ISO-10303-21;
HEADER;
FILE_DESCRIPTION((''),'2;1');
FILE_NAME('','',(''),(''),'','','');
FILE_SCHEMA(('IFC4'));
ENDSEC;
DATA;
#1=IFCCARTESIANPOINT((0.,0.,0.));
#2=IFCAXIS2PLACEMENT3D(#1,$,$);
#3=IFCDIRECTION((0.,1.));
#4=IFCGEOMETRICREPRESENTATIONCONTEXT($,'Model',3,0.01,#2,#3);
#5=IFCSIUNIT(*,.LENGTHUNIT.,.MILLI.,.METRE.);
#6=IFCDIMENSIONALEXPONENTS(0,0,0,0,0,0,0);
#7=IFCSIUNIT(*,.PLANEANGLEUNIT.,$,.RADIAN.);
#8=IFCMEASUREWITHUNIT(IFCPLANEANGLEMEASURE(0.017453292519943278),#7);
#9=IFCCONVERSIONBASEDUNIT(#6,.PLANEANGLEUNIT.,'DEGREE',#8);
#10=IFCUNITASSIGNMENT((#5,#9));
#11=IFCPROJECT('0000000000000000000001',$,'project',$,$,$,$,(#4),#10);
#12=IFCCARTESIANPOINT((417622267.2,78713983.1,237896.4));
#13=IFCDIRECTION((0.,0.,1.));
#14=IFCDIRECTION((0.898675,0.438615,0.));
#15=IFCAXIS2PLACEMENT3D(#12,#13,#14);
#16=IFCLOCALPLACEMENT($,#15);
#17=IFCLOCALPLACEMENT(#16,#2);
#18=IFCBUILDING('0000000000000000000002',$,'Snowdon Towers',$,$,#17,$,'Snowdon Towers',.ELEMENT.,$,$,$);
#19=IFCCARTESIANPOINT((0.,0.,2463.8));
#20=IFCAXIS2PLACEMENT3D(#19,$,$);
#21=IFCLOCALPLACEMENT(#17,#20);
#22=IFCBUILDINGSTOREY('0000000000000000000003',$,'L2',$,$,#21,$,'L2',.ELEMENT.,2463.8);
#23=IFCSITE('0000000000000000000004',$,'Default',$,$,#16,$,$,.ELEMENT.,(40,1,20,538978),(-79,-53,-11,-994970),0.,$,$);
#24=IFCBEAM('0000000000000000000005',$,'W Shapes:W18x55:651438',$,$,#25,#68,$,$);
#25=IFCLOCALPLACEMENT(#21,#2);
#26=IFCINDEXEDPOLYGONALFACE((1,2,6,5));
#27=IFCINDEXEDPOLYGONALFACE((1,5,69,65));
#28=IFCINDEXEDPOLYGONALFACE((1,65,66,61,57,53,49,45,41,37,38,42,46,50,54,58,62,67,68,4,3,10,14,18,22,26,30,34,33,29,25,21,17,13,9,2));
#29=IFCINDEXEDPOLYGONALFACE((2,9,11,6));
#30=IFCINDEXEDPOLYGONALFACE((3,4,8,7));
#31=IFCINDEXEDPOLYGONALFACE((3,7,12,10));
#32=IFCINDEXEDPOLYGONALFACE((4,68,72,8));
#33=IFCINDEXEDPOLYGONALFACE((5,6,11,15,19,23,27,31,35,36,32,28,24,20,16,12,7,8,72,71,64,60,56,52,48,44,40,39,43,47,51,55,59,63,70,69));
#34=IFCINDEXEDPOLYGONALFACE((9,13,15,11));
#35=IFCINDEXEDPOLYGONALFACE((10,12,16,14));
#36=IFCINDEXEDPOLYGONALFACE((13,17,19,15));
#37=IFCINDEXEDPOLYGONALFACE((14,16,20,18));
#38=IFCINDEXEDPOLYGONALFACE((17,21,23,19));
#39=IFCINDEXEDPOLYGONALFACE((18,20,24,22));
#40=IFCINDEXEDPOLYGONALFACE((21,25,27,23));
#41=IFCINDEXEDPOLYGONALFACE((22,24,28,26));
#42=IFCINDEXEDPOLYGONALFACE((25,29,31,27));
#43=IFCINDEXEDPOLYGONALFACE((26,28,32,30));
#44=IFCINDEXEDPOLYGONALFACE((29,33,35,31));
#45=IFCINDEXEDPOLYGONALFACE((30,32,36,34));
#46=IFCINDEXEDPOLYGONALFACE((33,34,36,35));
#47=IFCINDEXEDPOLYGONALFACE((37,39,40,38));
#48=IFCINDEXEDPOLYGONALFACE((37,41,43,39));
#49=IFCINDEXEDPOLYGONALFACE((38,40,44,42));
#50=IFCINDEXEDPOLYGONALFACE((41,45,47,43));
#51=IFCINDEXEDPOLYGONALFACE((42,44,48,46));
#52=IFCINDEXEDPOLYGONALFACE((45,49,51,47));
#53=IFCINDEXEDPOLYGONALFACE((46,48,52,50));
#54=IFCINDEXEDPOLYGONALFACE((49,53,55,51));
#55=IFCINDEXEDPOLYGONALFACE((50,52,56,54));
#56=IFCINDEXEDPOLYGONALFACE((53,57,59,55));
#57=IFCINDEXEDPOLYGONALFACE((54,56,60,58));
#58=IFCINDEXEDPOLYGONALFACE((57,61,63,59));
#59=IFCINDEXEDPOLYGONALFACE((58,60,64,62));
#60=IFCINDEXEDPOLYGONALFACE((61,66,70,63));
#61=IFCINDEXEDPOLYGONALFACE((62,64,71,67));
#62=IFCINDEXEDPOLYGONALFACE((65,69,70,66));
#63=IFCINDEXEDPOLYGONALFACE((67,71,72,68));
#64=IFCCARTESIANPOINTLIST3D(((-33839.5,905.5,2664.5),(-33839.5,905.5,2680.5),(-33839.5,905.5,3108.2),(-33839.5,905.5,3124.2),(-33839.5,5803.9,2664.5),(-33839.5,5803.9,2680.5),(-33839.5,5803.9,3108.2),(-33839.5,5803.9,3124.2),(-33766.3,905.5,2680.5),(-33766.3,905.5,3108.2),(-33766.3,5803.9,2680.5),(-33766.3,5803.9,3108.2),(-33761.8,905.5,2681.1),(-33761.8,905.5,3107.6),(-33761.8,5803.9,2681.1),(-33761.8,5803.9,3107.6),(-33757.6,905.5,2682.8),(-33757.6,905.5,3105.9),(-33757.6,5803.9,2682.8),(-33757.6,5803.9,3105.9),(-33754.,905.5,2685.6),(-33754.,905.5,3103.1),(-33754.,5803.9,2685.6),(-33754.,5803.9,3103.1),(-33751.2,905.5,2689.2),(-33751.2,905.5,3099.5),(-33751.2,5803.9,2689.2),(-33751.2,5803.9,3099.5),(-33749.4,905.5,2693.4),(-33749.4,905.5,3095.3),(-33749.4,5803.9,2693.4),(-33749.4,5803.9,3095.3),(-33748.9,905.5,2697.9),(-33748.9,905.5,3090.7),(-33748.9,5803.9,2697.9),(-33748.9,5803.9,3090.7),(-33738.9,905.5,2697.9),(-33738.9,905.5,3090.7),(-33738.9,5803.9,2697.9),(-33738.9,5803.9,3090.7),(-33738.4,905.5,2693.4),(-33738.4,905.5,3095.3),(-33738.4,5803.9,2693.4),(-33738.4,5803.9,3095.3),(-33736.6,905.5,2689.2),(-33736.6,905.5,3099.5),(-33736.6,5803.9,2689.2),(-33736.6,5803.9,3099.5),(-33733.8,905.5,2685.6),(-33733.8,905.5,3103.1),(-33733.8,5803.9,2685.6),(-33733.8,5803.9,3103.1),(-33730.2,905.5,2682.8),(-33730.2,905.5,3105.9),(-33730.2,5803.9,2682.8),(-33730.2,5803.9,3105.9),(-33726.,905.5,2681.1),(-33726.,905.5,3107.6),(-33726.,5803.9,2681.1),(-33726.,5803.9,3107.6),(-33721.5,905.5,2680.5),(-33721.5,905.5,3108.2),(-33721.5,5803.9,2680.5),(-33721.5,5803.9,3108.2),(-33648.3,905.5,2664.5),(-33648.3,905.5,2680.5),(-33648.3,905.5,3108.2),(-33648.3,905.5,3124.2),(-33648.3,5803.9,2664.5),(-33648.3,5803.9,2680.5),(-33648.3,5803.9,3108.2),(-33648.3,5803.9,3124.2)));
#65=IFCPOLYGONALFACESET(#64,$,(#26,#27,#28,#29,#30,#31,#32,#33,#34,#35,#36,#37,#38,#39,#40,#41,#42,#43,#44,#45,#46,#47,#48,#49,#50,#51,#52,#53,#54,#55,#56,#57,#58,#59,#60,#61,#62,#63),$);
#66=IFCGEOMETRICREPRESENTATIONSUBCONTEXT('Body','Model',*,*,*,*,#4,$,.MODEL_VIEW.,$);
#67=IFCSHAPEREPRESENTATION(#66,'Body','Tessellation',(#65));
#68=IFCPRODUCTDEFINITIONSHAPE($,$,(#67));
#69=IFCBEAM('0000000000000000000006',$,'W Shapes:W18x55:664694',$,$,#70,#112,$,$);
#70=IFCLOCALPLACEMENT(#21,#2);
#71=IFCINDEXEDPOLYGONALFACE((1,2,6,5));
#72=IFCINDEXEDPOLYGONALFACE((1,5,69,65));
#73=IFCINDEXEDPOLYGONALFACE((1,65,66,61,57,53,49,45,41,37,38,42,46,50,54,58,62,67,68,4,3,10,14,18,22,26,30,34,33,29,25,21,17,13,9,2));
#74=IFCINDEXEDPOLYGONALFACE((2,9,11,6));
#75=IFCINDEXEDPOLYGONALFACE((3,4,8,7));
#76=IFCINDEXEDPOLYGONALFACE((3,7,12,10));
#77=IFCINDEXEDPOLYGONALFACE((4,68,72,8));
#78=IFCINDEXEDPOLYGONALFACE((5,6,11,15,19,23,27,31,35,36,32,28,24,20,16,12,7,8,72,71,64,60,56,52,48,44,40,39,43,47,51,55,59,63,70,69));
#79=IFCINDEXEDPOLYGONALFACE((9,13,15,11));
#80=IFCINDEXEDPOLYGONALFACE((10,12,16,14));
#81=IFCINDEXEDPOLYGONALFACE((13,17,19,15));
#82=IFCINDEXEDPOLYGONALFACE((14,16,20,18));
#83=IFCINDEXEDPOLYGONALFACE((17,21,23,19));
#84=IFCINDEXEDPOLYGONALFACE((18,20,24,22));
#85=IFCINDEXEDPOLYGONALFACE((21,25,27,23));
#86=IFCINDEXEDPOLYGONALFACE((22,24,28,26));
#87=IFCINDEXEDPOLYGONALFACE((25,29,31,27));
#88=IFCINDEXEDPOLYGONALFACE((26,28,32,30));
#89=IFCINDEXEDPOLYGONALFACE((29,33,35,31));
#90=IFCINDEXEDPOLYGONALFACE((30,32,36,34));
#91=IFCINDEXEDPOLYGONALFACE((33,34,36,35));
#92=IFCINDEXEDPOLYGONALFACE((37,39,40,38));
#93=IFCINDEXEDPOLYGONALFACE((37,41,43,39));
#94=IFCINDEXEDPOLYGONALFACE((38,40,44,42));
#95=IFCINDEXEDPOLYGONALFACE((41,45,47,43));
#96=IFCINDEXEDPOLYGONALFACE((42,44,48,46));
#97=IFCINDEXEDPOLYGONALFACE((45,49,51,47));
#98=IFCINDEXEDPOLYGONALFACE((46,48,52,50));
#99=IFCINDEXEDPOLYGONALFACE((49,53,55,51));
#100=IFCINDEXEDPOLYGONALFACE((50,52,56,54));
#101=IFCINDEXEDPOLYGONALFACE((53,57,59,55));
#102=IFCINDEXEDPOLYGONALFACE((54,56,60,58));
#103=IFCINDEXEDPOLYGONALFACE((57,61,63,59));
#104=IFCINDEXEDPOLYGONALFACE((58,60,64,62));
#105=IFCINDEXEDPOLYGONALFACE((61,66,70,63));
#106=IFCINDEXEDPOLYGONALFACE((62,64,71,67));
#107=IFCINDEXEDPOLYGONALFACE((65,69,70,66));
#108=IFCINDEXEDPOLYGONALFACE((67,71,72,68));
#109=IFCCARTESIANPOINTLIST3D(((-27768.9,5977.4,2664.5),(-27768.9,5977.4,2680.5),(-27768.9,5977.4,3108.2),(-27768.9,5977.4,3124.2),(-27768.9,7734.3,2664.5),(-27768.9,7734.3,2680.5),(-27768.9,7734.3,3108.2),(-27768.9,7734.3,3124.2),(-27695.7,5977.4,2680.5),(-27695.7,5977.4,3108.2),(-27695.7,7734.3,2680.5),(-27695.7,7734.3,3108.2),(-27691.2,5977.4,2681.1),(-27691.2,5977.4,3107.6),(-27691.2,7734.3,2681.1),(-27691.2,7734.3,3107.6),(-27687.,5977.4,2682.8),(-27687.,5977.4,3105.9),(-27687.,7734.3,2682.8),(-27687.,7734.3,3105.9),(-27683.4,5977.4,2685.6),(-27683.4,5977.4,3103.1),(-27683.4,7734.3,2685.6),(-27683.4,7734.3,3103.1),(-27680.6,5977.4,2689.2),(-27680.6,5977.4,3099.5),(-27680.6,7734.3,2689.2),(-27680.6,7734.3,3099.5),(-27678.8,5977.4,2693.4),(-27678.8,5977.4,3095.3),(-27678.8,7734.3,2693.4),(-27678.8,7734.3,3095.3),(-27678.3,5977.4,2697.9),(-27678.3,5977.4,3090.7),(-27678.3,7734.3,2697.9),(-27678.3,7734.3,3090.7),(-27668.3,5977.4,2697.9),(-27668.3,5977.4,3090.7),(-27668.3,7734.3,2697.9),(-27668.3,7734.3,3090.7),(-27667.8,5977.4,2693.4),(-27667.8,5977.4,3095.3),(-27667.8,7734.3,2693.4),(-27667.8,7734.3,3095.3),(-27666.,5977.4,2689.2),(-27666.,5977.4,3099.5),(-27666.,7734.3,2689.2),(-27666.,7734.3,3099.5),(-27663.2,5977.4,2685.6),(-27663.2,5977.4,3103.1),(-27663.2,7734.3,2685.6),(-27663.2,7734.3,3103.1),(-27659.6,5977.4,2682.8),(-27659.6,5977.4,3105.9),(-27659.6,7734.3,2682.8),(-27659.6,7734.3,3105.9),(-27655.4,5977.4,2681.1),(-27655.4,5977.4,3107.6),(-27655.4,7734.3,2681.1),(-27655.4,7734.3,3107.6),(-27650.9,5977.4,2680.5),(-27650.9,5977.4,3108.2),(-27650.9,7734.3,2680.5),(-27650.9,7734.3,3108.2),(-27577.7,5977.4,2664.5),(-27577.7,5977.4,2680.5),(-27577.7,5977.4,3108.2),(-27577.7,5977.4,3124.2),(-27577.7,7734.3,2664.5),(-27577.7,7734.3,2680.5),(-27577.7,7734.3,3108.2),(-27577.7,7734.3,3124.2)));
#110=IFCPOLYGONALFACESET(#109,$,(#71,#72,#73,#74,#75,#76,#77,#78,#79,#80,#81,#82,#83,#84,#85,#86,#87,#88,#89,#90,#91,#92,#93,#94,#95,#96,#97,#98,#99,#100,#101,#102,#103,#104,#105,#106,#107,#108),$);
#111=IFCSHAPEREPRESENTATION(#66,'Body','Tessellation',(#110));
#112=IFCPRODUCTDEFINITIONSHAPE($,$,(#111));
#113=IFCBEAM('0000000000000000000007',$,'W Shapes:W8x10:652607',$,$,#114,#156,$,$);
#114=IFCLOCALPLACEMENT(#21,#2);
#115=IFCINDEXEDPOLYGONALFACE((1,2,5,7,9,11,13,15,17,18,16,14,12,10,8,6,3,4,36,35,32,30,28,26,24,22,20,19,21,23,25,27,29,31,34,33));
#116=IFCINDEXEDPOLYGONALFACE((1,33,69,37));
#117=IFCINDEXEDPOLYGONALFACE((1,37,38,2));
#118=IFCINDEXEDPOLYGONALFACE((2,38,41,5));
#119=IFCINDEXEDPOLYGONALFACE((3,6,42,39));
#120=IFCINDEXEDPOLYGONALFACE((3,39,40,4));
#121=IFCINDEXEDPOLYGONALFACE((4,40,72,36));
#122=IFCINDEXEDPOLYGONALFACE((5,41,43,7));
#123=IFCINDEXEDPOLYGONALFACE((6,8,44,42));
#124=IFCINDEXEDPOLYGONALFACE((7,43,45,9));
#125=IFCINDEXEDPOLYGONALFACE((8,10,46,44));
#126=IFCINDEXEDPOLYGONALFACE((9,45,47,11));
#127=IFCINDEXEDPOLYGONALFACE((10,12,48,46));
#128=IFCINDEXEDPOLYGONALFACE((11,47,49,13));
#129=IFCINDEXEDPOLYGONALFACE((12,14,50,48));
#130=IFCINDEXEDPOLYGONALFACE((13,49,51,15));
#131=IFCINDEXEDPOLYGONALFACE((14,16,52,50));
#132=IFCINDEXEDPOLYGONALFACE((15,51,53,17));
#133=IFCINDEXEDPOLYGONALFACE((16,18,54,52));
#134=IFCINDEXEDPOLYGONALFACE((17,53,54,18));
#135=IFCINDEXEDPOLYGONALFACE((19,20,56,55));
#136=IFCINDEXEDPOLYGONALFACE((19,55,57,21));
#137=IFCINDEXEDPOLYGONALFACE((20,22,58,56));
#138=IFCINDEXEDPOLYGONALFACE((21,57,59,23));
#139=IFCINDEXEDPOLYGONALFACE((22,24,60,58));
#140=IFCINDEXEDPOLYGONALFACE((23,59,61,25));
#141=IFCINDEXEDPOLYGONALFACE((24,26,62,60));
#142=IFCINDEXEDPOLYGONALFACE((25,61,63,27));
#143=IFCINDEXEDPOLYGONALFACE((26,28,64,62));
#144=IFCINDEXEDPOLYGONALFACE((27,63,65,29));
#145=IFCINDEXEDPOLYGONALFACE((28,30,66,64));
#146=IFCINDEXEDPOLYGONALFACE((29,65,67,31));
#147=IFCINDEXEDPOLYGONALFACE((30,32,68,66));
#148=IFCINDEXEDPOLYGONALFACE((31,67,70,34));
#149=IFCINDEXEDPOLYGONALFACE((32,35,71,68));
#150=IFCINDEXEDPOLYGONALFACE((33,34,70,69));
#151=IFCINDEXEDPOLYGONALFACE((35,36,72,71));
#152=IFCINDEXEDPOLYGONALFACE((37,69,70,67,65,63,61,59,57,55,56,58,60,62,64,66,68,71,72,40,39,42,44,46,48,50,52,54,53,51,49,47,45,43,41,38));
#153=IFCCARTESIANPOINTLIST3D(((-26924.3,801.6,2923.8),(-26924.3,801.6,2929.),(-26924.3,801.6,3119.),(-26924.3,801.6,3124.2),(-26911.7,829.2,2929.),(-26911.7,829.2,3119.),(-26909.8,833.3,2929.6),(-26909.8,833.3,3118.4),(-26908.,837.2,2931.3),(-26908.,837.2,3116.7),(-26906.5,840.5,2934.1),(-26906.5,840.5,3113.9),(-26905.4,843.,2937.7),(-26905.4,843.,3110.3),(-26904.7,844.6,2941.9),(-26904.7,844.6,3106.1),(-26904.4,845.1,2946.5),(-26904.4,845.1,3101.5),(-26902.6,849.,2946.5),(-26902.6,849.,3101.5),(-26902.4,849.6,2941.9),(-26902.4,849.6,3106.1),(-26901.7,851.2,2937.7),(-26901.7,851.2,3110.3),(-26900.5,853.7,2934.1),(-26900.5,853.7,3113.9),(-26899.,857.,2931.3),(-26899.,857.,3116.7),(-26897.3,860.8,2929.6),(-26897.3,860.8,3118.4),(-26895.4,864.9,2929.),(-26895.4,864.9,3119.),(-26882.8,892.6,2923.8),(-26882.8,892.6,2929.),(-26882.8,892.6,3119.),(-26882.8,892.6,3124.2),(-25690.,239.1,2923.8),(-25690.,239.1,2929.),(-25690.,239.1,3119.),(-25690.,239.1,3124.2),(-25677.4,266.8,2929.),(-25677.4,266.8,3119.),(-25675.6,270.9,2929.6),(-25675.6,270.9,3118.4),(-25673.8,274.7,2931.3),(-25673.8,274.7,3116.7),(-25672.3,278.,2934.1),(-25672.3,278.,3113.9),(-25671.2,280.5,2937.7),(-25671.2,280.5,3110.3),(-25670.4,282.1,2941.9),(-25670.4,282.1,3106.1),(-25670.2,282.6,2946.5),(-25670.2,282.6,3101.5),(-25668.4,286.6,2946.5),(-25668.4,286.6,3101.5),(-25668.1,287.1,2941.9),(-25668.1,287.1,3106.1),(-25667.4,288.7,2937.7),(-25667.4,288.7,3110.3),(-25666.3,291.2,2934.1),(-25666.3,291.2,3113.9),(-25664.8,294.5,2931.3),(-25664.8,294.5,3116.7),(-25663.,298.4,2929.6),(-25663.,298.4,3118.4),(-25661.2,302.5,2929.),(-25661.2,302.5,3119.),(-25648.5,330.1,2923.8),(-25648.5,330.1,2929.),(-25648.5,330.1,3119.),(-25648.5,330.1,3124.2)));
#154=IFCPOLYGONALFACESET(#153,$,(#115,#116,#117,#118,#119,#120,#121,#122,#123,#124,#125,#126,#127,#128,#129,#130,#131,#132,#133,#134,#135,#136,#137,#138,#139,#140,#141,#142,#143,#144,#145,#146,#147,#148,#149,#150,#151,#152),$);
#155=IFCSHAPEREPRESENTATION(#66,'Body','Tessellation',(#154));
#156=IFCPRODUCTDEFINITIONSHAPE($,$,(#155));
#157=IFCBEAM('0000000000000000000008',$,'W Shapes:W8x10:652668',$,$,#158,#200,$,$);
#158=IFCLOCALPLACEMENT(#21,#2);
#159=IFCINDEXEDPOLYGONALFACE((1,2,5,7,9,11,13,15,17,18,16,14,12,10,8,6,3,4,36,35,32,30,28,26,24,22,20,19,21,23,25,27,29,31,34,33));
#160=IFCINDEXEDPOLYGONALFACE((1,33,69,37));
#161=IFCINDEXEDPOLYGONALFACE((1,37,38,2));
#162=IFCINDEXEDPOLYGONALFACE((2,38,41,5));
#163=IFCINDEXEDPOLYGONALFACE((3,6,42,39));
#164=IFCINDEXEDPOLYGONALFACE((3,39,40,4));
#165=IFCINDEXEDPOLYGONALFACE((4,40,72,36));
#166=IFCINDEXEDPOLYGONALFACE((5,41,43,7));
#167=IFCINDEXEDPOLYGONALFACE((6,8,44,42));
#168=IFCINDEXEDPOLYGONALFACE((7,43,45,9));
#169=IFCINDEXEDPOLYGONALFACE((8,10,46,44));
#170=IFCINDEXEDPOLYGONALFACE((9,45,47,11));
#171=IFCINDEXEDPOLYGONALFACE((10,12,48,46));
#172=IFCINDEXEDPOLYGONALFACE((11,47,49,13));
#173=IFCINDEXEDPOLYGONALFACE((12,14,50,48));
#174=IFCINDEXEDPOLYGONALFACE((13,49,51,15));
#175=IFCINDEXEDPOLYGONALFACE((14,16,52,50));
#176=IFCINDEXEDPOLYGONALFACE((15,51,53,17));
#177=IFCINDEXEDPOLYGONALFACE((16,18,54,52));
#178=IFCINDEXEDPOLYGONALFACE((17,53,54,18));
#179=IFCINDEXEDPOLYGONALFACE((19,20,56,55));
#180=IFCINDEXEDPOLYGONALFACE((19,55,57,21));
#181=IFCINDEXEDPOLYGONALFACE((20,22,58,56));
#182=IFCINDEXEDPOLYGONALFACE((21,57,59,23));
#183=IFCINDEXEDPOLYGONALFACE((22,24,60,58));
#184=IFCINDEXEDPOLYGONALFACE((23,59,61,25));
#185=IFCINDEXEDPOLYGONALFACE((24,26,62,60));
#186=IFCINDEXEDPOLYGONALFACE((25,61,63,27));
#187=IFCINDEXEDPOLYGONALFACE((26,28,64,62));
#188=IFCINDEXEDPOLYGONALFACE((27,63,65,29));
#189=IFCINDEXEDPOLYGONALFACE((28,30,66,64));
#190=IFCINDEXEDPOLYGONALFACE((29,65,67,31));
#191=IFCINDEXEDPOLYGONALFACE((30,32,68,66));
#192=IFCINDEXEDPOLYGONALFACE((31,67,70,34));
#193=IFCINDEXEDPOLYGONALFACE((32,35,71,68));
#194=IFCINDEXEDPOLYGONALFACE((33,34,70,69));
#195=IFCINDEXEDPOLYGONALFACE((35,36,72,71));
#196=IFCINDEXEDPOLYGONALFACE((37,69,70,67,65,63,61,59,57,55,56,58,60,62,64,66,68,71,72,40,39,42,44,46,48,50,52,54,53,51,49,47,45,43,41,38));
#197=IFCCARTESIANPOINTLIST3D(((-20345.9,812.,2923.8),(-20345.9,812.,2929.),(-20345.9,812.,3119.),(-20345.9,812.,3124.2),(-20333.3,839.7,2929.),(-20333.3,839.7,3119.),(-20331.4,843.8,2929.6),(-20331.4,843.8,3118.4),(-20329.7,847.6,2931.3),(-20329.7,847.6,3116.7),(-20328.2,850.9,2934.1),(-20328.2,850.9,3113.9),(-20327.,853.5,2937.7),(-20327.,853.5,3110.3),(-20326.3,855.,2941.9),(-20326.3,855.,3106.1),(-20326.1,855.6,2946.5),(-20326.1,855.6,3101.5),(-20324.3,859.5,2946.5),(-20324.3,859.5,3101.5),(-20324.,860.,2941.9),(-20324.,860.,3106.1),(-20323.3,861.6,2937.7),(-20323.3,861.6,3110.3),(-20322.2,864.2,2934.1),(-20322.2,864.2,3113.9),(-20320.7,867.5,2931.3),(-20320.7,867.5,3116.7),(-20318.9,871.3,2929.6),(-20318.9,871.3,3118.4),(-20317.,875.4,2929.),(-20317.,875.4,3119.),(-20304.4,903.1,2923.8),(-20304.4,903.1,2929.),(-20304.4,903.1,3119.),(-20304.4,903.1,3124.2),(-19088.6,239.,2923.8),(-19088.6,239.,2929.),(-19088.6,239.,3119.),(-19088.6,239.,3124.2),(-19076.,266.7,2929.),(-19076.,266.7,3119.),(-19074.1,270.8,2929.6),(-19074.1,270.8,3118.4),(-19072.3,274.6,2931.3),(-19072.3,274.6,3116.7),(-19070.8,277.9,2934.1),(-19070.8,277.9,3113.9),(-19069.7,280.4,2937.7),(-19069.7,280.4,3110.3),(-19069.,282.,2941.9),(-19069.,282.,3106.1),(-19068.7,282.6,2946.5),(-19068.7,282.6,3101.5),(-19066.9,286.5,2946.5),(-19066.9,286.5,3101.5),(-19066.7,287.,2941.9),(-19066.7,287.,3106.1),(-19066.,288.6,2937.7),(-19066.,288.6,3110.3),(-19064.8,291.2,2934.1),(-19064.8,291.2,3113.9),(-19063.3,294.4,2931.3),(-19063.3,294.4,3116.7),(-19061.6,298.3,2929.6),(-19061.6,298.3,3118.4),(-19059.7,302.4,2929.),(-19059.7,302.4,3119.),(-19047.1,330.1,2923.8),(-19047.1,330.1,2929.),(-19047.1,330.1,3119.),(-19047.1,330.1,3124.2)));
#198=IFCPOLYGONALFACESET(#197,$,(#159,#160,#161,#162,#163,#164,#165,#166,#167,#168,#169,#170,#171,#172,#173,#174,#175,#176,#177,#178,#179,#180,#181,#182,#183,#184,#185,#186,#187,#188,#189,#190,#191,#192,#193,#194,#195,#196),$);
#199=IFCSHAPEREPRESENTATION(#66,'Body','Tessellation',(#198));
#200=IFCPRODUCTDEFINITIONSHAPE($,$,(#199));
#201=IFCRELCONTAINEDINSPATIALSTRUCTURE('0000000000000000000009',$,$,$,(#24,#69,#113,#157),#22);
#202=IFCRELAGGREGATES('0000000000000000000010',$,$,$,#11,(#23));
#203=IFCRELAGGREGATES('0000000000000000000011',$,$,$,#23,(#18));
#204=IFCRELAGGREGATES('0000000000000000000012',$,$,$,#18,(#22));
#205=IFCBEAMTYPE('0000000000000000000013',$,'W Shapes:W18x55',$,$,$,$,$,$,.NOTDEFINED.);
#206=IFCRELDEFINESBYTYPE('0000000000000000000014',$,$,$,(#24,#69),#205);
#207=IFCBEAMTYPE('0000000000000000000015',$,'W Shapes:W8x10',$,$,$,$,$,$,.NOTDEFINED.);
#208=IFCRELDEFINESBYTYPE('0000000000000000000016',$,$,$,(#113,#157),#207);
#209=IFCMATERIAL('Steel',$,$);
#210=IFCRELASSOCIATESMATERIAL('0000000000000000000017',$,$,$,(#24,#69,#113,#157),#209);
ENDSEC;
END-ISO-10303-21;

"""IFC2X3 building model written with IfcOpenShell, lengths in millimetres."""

from ifc_helpers import new_model, entity, si_unit, converted_unit, direction, frame, frame_2d, origin, place, context, subcontext, project, spatial, i_section, extrude, material, type_object, element, save


model = new_model("IFC2X3")

# Units and contexts
model_context = context("Model", 3, precision=0.01, world=origin(), true_north=direction((0.0, 1.0)))
body_context = subcontext(model_context, "Body", "Model", "MODEL_VIEW")
ifc_project = project(units=[si_unit("LENGTHUNIT", "METRE", prefix="MILLI"), converted_unit("PLANEANGLEUNIT", "DEGREE", entity("IfcPlaneAngleMeasure", 0.017453292519943278), si_unit("PLANEANGLEUNIT", "RADIAN"), dimensions=[0, 0, 0, 0, 0, 0, 0])], contexts=[model_context])

# Site, building, storey
site_placement = place(None, frame((417622267.2, 78713983.1, 237896.4), z_axis=(0.0, 0.0, 1.0), x_axis=(0.898675, 0.438615, 0.0)))
site = spatial("IfcSite", under=ifc_project, at=site_placement, Name="Default", CompositionType="ELEMENT", RefLatitude=(40, 1, 20, 538978), RefLongitude=(-79, -53, -11, -994970), RefElevation=0.0)
building_placement = place(site_placement, origin())
building = spatial("IfcBuilding", under=site, at=building_placement, Name="Snowdon Towers", LongName="Snowdon Towers", CompositionType="ELEMENT")
storey_placement = place(building_placement, frame((0.0, 0.0, 2463.8)))
storey = spatial("IfcBuildingStorey", under=building, at=storey_placement, Name="L2", LongName="L2", CompositionType="ELEMENT", Elevation=2463.8)

# Beams
ifc_material = material(Name="Steel")
beam_type_1 = type_object("IfcBeamType", Name="W Shapes:W18x55", PredefinedType="NOTDEFINED")
beam_1_placement = place(storey_placement, frame((-33743.9, 762.0, 3124.2), z_axis=(0.0, 0.0, 1.0), x_axis=(0.0, 1.0, 0.0)))
element("IfcBeam", 1, at=beam_1_placement, inside=storey, type_object=beam_type_1, material=ifc_material, Name="W Shapes:W18x55:651438", context=body_context, shape_type="SweptSolid", body=[
    extrude(i_section(OverallWidth=191.3, OverallDepth=459.7, WebThickness=9.9, FlangeThickness=16.0, FilletRadius=17.5, at=frame_2d((0.0, 0.0), x_axis=(0.0, 1.0))), frame((143.5, 0.0, -229.9), z_axis=(1.0, 0.0, 0.0), x_axis=(0.0, 0.0, -1.0)), (0.0, 0.0, 1.0), 4898.4),
])
beam_2_placement = place(storey_placement, frame((-27673.3, 5854.7, 3124.2), z_axis=(0.0, 0.0, 1.0), x_axis=(0.0, 1.0, 0.0)))
element("IfcBeam", 2, at=beam_2_placement, inside=storey, type_object=beam_type_1, material=ifc_material, Name="W Shapes:W18x55:664694", context=body_context, shape_type="SweptSolid", body=[
    extrude(i_section(OverallWidth=191.3, OverallDepth=459.7, WebThickness=9.9, FlangeThickness=16.0, FilletRadius=17.5, at=frame_2d((0.0, 0.0), x_axis=(0.0, 1.0))), frame((122.7, 0.0, -229.9), z_axis=(1.0, 0.0, 0.0), x_axis=(0.0, 0.0, -1.0)), (0.0, 0.0, 1.0), 1756.9),
])
beam_type_2 = type_object("IfcBeamType", Name="W Shapes:W8x10", PredefinedType="NOTDEFINED")
beam_3_placement = place(storey_placement, frame((-25541.0, 226.2, 3124.2), z_axis=(0.0, 0.0, 1.0), x_axis=(-0.909961, 0.414693, 0.0)))
element("IfcBeam", 3, at=beam_3_placement, inside=storey, type_object=beam_type_2, material=ifc_material, Name="W Shapes:W8x10:652607", context=body_context, shape_type="SweptSolid", body=[
    extrude(i_section(OverallWidth=100.1, OverallDepth=200.4, WebThickness=4.3, FlangeThickness=5.2, FilletRadius=17.5, at=frame_2d((0.0, 0.0), x_axis=(0.0, 1.0))), frame((141.0, 0.0, -100.2), z_axis=(1.0, 0.0, 0.0), x_axis=(0.0, 0.0, -1.0)), (0.0, 0.0, 1.0), 1356.4),
])
beam_4_placement = place(storey_placement, frame((-18939.6, 226.1, 3124.2), z_axis=(0.0, 0.0, 1.0), x_axis=(-0.909961, 0.414693, 0.0)))
element("IfcBeam", 4, at=beam_4_placement, inside=storey, type_object=beam_type_2, material=ifc_material, Name="W Shapes:W8x10:652668", context=body_context, shape_type="SweptSolid", body=[
    extrude(i_section(OverallWidth=100.1, OverallDepth=200.4, WebThickness=4.3, FlangeThickness=5.2, FilletRadius=17.5, at=frame_2d((0.0, 0.0), x_axis=(0.0, 1.0))), frame((141.0, 0.0, -100.2), z_axis=(1.0, 0.0, 0.0), x_axis=(0.0, 0.0, -1.0)), (0.0, 0.0, 1.0), 1381.8),
])

save(model, "model.ifc")
